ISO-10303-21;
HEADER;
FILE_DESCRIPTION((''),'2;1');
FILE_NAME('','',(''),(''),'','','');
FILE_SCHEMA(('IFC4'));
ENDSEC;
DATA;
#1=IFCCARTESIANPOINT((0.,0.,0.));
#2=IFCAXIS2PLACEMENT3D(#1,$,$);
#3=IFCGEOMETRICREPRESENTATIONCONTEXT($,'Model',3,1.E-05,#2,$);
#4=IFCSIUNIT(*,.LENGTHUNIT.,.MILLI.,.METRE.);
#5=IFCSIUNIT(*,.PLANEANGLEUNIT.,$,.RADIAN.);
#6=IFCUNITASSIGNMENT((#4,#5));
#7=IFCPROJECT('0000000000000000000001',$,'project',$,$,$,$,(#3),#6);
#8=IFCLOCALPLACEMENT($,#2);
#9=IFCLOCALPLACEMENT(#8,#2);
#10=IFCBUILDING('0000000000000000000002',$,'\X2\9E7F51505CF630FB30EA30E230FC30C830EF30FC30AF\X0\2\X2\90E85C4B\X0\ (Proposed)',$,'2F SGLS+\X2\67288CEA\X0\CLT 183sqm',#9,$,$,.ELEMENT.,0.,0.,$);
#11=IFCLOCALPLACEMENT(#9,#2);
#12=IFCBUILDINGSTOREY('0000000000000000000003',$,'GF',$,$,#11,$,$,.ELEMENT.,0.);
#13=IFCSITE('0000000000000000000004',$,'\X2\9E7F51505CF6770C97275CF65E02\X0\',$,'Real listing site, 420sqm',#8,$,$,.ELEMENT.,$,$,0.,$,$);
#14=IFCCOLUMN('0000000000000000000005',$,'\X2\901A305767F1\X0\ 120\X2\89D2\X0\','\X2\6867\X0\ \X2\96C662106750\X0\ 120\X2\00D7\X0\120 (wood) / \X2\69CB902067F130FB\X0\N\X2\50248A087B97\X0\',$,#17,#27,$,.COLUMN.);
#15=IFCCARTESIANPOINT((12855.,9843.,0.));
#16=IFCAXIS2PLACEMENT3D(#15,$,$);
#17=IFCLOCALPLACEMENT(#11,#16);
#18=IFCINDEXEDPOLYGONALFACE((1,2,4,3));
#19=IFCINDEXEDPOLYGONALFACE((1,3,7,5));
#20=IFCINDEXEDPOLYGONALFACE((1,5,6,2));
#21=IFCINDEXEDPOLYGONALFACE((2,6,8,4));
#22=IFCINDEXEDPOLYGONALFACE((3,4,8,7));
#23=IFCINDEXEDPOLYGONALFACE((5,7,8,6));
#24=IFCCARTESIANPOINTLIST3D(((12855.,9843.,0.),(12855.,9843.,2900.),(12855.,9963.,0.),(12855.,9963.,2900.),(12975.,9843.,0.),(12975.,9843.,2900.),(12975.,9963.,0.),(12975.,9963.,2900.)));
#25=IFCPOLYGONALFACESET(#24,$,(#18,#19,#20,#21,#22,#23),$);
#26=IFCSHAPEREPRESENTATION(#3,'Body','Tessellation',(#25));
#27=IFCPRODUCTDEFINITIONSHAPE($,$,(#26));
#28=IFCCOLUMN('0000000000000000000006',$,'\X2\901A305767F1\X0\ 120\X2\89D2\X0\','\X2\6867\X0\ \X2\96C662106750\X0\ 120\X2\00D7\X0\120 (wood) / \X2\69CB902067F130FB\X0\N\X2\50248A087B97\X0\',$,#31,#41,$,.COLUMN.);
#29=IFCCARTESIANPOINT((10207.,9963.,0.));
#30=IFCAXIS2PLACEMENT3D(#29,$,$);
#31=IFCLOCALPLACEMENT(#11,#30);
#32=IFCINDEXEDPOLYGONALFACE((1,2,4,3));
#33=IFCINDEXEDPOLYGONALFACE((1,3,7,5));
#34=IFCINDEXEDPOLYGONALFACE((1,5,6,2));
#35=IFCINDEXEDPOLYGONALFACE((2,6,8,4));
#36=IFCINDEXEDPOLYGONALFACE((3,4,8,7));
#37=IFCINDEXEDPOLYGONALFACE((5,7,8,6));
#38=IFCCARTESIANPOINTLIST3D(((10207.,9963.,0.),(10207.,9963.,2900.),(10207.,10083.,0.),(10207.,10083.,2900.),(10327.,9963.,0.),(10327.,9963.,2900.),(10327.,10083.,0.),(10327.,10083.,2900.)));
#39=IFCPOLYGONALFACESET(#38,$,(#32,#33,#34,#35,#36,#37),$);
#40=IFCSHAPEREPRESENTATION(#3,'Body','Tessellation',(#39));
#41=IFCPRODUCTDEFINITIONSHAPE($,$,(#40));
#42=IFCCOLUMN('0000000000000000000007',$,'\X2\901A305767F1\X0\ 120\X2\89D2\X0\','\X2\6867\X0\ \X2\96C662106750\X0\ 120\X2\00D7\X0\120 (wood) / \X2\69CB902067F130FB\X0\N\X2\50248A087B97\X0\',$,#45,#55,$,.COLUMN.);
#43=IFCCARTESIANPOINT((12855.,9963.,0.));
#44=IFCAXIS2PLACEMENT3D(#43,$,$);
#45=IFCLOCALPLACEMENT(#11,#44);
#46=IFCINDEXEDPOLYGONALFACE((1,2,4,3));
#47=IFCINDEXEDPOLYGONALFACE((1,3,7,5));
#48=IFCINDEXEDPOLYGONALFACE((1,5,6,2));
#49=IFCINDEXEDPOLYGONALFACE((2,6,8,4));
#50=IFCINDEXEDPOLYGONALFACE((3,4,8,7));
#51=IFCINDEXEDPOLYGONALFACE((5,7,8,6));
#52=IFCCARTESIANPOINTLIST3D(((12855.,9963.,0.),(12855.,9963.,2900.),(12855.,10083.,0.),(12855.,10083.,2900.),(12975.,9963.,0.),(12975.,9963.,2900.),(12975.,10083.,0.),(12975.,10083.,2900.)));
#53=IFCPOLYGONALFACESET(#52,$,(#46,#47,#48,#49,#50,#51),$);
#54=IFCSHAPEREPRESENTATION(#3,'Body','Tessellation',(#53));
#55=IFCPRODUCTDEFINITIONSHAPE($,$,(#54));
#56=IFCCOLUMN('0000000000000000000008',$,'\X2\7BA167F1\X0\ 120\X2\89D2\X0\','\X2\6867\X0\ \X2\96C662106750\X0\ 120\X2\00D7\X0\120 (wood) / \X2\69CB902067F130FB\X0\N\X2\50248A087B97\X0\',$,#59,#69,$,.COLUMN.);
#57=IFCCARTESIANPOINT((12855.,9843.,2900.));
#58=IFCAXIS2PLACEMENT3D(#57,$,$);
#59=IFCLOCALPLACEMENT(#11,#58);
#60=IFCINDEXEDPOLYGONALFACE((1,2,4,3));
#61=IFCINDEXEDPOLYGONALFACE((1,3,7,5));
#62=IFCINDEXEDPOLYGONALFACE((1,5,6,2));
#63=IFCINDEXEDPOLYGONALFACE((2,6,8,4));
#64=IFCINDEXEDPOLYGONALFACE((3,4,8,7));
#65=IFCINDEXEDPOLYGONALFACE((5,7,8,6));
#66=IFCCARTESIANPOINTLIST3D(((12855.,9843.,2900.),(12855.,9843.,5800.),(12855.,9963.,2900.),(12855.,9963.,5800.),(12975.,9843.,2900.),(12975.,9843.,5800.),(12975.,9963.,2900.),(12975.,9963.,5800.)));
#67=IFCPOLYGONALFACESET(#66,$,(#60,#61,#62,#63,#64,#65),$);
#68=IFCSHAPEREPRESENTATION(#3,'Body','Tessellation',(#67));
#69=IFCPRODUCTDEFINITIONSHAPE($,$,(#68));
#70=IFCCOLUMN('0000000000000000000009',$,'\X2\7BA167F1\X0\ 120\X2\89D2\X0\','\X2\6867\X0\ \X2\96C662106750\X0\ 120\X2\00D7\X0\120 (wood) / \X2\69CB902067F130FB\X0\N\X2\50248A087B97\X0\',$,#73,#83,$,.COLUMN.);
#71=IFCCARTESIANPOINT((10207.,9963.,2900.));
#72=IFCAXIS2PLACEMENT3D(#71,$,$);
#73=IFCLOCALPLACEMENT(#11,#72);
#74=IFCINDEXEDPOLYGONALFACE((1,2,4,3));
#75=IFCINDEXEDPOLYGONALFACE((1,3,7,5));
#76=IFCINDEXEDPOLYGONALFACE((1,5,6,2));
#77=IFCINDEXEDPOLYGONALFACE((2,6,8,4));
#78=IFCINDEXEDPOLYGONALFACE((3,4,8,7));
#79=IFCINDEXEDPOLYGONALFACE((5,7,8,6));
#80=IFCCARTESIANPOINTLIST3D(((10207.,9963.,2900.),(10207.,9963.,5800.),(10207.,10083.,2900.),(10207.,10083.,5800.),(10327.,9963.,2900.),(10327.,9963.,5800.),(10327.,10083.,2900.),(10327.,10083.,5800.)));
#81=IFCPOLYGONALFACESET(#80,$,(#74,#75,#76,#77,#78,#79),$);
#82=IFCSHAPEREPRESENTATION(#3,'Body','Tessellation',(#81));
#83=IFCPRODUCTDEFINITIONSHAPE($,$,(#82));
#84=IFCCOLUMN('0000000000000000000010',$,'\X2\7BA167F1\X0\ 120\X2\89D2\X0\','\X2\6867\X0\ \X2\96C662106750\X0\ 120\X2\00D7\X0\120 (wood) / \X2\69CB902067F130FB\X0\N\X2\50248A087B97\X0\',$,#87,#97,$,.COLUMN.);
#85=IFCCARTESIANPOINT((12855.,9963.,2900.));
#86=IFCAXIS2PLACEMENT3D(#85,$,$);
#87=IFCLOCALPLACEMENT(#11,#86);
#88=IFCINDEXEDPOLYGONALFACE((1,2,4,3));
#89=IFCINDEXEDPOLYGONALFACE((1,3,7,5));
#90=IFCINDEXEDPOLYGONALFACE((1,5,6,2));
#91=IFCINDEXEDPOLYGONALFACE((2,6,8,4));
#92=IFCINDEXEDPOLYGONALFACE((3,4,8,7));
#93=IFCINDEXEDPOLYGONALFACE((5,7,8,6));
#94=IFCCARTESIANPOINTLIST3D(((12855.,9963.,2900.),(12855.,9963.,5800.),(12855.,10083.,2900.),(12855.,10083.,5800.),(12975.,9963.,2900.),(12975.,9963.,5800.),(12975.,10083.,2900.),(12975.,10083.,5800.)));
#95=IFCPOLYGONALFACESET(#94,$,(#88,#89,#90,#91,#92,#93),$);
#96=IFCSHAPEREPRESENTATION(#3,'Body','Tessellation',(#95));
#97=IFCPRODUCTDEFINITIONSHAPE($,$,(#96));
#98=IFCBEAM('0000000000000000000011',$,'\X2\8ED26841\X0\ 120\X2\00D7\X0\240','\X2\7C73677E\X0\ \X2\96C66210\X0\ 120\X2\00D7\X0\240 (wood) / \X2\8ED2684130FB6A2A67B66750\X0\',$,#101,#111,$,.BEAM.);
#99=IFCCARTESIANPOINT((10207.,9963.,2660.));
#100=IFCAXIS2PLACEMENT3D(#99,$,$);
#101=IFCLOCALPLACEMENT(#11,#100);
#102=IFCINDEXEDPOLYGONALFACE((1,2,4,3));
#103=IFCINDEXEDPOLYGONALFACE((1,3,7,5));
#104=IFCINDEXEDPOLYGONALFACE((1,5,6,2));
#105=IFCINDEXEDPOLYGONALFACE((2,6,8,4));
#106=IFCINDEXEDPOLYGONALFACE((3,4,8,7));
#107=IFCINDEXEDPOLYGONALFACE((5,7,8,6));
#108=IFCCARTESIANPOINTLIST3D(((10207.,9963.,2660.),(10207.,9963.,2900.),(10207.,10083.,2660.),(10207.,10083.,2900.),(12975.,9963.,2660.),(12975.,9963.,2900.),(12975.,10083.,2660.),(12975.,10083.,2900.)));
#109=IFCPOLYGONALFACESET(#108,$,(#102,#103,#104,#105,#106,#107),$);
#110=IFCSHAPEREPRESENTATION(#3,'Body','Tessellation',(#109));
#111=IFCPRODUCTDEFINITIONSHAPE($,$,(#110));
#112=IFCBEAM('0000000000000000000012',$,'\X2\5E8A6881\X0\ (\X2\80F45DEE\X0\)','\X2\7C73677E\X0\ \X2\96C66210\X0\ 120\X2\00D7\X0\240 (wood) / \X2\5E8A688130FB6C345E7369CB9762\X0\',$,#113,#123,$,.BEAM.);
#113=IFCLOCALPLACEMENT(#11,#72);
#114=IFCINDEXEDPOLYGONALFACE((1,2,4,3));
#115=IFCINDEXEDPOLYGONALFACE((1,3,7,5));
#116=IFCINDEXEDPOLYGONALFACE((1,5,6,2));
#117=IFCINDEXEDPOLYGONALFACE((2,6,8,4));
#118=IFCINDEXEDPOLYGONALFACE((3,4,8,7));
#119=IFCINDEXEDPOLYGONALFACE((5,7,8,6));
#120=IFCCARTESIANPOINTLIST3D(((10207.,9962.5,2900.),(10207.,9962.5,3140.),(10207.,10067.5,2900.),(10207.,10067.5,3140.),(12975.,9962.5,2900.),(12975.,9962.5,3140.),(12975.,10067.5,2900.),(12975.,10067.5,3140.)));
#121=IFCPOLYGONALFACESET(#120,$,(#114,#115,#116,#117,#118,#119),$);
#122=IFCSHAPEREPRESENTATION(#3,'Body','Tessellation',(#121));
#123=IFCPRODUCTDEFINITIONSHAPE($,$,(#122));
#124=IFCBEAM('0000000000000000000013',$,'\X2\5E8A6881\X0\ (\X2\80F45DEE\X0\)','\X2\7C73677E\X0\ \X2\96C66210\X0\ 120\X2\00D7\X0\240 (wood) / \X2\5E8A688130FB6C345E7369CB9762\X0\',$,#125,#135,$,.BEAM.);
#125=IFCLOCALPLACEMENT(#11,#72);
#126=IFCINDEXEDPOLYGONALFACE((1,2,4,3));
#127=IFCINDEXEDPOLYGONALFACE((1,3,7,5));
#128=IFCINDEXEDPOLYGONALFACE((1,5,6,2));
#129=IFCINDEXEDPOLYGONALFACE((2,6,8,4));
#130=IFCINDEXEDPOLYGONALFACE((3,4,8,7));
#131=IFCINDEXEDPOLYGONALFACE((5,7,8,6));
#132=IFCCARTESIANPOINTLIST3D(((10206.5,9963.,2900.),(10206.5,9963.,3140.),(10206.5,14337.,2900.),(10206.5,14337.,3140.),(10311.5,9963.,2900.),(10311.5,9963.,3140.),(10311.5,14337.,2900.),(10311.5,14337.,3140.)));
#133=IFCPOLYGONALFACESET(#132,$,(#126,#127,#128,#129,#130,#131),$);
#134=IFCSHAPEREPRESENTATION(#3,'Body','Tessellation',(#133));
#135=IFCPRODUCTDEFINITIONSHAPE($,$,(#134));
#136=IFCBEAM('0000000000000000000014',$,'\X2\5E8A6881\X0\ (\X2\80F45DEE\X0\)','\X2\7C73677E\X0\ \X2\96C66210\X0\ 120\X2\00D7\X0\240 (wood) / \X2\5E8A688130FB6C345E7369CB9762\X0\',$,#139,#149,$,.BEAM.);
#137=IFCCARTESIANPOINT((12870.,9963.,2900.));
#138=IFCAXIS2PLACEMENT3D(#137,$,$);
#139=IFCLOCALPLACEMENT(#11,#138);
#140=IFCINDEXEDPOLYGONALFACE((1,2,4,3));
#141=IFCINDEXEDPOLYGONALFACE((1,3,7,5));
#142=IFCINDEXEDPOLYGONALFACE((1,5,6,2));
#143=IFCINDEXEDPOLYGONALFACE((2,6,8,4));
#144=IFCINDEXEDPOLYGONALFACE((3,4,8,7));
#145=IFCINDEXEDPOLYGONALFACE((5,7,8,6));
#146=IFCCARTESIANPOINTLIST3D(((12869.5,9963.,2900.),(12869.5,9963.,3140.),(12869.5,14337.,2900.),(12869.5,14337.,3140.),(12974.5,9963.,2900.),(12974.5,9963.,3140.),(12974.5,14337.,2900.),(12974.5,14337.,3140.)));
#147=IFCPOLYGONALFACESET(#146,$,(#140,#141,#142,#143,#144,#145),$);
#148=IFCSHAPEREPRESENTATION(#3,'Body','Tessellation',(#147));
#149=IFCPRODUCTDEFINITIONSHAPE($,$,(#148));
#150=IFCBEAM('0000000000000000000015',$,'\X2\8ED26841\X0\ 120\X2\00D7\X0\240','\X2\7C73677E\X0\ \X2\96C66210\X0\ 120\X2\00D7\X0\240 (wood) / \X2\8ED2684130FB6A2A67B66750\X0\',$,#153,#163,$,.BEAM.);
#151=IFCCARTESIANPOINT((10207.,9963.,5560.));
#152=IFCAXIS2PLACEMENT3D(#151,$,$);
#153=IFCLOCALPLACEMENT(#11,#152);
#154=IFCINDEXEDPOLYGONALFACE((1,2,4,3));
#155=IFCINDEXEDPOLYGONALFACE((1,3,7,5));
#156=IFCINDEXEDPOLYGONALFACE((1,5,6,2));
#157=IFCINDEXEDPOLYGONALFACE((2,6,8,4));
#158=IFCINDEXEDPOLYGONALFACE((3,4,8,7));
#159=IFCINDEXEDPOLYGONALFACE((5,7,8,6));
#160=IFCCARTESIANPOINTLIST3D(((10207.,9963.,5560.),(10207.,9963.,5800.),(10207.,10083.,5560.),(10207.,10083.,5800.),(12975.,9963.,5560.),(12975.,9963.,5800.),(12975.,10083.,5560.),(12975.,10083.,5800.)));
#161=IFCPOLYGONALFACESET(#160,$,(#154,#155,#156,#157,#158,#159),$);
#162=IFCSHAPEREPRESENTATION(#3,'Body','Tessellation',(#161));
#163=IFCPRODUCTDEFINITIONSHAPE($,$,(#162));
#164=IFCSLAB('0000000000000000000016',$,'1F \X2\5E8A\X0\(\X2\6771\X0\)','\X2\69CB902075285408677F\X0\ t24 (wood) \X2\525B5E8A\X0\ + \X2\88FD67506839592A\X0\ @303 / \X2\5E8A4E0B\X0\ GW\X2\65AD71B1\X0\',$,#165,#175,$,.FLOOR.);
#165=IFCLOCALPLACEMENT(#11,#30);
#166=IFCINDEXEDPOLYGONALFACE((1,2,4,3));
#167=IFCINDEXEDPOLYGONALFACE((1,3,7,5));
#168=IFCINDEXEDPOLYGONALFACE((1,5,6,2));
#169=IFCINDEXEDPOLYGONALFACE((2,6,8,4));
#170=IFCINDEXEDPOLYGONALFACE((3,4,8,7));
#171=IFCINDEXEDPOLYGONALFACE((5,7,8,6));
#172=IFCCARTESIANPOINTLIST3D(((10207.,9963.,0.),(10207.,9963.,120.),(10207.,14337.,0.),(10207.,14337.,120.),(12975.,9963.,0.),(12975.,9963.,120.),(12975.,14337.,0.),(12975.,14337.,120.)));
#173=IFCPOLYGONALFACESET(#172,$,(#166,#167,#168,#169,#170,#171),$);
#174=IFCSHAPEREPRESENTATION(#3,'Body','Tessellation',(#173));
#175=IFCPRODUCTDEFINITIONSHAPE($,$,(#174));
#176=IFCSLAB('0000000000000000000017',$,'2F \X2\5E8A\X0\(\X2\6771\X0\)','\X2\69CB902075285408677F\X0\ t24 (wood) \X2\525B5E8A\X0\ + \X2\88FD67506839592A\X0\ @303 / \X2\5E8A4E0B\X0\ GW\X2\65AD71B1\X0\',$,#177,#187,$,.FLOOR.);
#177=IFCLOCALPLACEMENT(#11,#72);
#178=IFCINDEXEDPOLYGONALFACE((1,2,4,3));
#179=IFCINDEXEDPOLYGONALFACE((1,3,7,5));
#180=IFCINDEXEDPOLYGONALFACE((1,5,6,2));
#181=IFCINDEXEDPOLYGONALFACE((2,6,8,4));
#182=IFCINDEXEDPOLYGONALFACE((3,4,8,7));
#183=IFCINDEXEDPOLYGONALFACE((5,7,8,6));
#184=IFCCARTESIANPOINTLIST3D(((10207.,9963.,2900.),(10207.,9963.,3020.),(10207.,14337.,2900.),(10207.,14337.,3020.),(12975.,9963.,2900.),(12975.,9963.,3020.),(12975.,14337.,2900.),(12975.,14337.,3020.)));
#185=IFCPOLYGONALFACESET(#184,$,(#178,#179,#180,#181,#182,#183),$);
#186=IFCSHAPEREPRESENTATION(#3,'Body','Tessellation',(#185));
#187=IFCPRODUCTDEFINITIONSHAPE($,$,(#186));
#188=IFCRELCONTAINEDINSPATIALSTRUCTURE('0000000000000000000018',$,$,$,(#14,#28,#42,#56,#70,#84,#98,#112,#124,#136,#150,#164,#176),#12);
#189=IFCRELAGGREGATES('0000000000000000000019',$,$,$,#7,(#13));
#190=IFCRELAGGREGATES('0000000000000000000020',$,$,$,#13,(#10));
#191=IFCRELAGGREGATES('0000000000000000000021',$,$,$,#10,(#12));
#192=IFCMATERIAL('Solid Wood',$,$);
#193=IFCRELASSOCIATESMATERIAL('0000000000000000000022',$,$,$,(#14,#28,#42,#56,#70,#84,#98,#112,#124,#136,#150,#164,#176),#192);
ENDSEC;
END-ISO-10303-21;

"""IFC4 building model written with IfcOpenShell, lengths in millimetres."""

from ifc_helpers import new_model, si_unit, frame, frame_2d, origin, place, context, project, spatial, rectangle, extrude, material, element, save


model = new_model("IFC4")

# Units and contexts
model_context = context("Model", 3, precision=1e-05, world=origin())
ifc_project = project(units=[si_unit("LENGTHUNIT", "METRE", prefix="MILLI"), si_unit("PLANEANGLEUNIT", "RADIAN")], contexts=[model_context])

# Site, building, storey
site_placement = place(None, origin())
site = spatial("IfcSite", under=ifc_project, at=site_placement, Name="鹿児島県霧島市", ObjectType="Real listing site, 420sqm", CompositionType="ELEMENT", RefElevation=0.0)
building_placement = place(site_placement, origin())
building = spatial("IfcBuilding", under=site, at=building_placement, Name="鹿児島・リモートワーク2部屋 (Proposed)", ObjectType="2F SGLS+木質CLT 183sqm", CompositionType="ELEMENT", ElevationOfRefHeight=0.0, ElevationOfTerrain=0.0)
storey_placement = place(building_placement, origin())
storey = spatial("IfcBuildingStorey", under=building, at=storey_placement, Name="GF", CompositionType="ELEMENT", Elevation=0.0)

# Columns
ifc_material_1 = material(Name="Solid Wood")
column_1_placement = place(storey_placement, frame((12855.0, 9843.0, 0.0)))
element("IfcColumn", 1, at=column_1_placement, inside=storey, material=ifc_material_1, Name="通し柱 120角", Description="桧 集成材 120×120 (wood) / 構造柱・N値計算", PredefinedType="COLUMN", context=model_context, shape_type="SweptSolid", body=[
    extrude(rectangle(XDim=120.0, YDim=120.0, at=frame_2d((60.0, 60.0))), frame((12855.0, 9843.0, 0.0)), (0.0, 0.0, 1.0), 2900.0),
])
column_2_placement = place(storey_placement, frame((10207.0, 9963.0, 0.0)))
element("IfcColumn", 2, at=column_2_placement, inside=storey, material=ifc_material_1, Name="通し柱 120角", Description="桧 集成材 120×120 (wood) / 構造柱・N値計算", PredefinedType="COLUMN", context=model_context, shape_type="SweptSolid", body=[
    extrude(rectangle(XDim=120.0, YDim=120.0, at=frame_2d((60.0, 60.0))), frame((10207.0, 9963.0, 0.0)), (0.0, 0.0, 1.0), 2900.0),
])
column_3_placement = place(storey_placement, frame((12855.0, 9963.0, 0.0)))
element("IfcColumn", 3, at=column_3_placement, inside=storey, material=ifc_material_1, Name="通し柱 120角", Description="桧 集成材 120×120 (wood) / 構造柱・N値計算", PredefinedType="COLUMN", context=model_context, shape_type="SweptSolid", body=[
    extrude(rectangle(XDim=120.0, YDim=120.0, at=frame_2d((60.0, 60.0))), frame((12855.0, 9963.0, 0.0)), (0.0, 0.0, 1.0), 2900.0),
])
column_4_placement = place(storey_placement, frame((12855.0, 9843.0, 2900.0)))
element("IfcColumn", 4, at=column_4_placement, inside=storey, material=ifc_material_1, Name="管柱 120角", Description="桧 集成材 120×120 (wood) / 構造柱・N値計算", PredefinedType="COLUMN", context=model_context, shape_type="SweptSolid", body=[
    extrude(rectangle(XDim=120.0, YDim=120.0, at=frame_2d((60.0, 60.0))), frame((12855.0, 9843.0, 2900.0)), (0.0, 0.0, 1.0), 2900.0),
])
column_5_placement = place(storey_placement, frame((10207.0, 9963.0, 2900.0)))
element("IfcColumn", 5, at=column_5_placement, inside=storey, material=ifc_material_1, Name="管柱 120角", Description="桧 集成材 120×120 (wood) / 構造柱・N値計算", PredefinedType="COLUMN", context=model_context, shape_type="SweptSolid", body=[
    extrude(rectangle(XDim=120.0, YDim=120.0, at=frame_2d((60.0, 60.0))), frame((10207.0, 9963.0, 2900.0)), (0.0, 0.0, 1.0), 2900.0),
])
column_6_placement = place(storey_placement, frame((12855.0, 9963.0, 2900.0)))
element("IfcColumn", 6, at=column_6_placement, inside=storey, material=ifc_material_1, Name="管柱 120角", Description="桧 集成材 120×120 (wood) / 構造柱・N値計算", PredefinedType="COLUMN", context=model_context, shape_type="SweptSolid", body=[
    extrude(rectangle(XDim=120.0, YDim=120.0, at=frame_2d((60.0, 60.0))), frame((12855.0, 9963.0, 2900.0)), (0.0, 0.0, 1.0), 2900.0),
])

# Beams
beam_1_placement = place(storey_placement, frame((10207.0, 9963.0, 2660.0)))
element("IfcBeam", 7, at=beam_1_placement, inside=storey, material=ifc_material_1, Name="軒桁 120×240", Description="米松 集成 120×240 (wood) / 軒桁・横架材", PredefinedType="BEAM", context=model_context, shape_type="SweptSolid", body=[
    extrude(rectangle(XDim=2768.0, YDim=120.0, at=frame_2d((1384.0, 60.0))), frame((10207.0, 9963.0, 2660.0)), (0.0, 0.0, 1.0), 240.0),
])
beam_2_placement = place(storey_placement, frame((10207.0, 9963.0, 2900.0)))
element("IfcBeam", 8, at=beam_2_placement, inside=storey, material=ifc_material_1, Name="床梁 (胴差)", Description="米松 集成 120×240 (wood) / 床梁・水平構面", PredefinedType="BEAM", context=model_context, shape_type="SweptSolid", body=[
    extrude(rectangle(XDim=2768.0, YDim=105.0, at=frame_2d((1384.0, 52.0))), frame((10207.0, 9963.0, 2900.0)), (0.0, 0.0, 1.0), 240.0),
])
beam_3_placement = place(storey_placement, frame((10207.0, 9963.0, 2900.0)))
element("IfcBeam", 9, at=beam_3_placement, inside=storey, material=ifc_material_1, Name="床梁 (胴差)", Description="米松 集成 120×240 (wood) / 床梁・水平構面", PredefinedType="BEAM", context=model_context, shape_type="SweptSolid", body=[
    extrude(rectangle(XDim=105.0, YDim=4374.0, at=frame_2d((52.0, 2187.0))), frame((10207.0, 9963.0, 2900.0)), (0.0, 0.0, 1.0), 240.0),
])
beam_4_placement = place(storey_placement, frame((12870.0, 9963.0, 2900.0)))
element("IfcBeam", 10, at=beam_4_placement, inside=storey, material=ifc_material_1, Name="床梁 (胴差)", Description="米松 集成 120×240 (wood) / 床梁・水平構面", PredefinedType="BEAM", context=model_context, shape_type="SweptSolid", body=[
    extrude(rectangle(XDim=105.0, YDim=4374.0, at=frame_2d((52.0, 2187.0))), frame((12870.0, 9963.0, 2900.0)), (0.0, 0.0, 1.0), 240.0),
])
beam_5_placement = place(storey_placement, frame((10207.0, 9963.0, 5560.0)))
element("IfcBeam", 11, at=beam_5_placement, inside=storey, material=ifc_material_1, Name="軒桁 120×240", Description="米松 集成 120×240 (wood) / 軒桁・横架材", PredefinedType="BEAM", context=model_context, shape_type="SweptSolid", body=[
    extrude(rectangle(XDim=2768.0, YDim=120.0, at=frame_2d((1384.0, 60.0))), frame((10207.0, 9963.0, 5560.0)), (0.0, 0.0, 1.0), 240.0),
])

# Slabs
slab_1_placement = place(storey_placement, frame((10207.0, 9963.0, 0.0)))
element("IfcSlab", 12, at=slab_1_placement, inside=storey, material=ifc_material_1, Name="1F 床(東)", Description="構造用合板 t24 (wood) 剛床 + 製材根太 @303 / 床下 GW断熱", PredefinedType="FLOOR", context=model_context, shape_type="SweptSolid", body=[
    extrude(rectangle(XDim=2768.0, YDim=4374.0, at=frame_2d((1384.0, 2187.0))), frame((10207.0, 9963.0, 0.0)), (0.0, 0.0, 1.0), 120.0),
])
slab_2_placement = place(storey_placement, frame((10207.0, 9963.0, 2900.0)))
element("IfcSlab", 13, at=slab_2_placement, inside=storey, material=ifc_material_1, Name="2F 床(東)", Description="構造用合板 t24 (wood) 剛床 + 製材根太 @303 / 床下 GW断熱", PredefinedType="FLOOR", context=model_context, shape_type="SweptSolid", body=[
    extrude(rectangle(XDim=2768.0, YDim=4374.0, at=frame_2d((1384.0, 2187.0))), frame((10207.0, 9963.0, 2900.0)), (0.0, 0.0, 1.0), 120.0),
])

save(model, "model.ifc")
